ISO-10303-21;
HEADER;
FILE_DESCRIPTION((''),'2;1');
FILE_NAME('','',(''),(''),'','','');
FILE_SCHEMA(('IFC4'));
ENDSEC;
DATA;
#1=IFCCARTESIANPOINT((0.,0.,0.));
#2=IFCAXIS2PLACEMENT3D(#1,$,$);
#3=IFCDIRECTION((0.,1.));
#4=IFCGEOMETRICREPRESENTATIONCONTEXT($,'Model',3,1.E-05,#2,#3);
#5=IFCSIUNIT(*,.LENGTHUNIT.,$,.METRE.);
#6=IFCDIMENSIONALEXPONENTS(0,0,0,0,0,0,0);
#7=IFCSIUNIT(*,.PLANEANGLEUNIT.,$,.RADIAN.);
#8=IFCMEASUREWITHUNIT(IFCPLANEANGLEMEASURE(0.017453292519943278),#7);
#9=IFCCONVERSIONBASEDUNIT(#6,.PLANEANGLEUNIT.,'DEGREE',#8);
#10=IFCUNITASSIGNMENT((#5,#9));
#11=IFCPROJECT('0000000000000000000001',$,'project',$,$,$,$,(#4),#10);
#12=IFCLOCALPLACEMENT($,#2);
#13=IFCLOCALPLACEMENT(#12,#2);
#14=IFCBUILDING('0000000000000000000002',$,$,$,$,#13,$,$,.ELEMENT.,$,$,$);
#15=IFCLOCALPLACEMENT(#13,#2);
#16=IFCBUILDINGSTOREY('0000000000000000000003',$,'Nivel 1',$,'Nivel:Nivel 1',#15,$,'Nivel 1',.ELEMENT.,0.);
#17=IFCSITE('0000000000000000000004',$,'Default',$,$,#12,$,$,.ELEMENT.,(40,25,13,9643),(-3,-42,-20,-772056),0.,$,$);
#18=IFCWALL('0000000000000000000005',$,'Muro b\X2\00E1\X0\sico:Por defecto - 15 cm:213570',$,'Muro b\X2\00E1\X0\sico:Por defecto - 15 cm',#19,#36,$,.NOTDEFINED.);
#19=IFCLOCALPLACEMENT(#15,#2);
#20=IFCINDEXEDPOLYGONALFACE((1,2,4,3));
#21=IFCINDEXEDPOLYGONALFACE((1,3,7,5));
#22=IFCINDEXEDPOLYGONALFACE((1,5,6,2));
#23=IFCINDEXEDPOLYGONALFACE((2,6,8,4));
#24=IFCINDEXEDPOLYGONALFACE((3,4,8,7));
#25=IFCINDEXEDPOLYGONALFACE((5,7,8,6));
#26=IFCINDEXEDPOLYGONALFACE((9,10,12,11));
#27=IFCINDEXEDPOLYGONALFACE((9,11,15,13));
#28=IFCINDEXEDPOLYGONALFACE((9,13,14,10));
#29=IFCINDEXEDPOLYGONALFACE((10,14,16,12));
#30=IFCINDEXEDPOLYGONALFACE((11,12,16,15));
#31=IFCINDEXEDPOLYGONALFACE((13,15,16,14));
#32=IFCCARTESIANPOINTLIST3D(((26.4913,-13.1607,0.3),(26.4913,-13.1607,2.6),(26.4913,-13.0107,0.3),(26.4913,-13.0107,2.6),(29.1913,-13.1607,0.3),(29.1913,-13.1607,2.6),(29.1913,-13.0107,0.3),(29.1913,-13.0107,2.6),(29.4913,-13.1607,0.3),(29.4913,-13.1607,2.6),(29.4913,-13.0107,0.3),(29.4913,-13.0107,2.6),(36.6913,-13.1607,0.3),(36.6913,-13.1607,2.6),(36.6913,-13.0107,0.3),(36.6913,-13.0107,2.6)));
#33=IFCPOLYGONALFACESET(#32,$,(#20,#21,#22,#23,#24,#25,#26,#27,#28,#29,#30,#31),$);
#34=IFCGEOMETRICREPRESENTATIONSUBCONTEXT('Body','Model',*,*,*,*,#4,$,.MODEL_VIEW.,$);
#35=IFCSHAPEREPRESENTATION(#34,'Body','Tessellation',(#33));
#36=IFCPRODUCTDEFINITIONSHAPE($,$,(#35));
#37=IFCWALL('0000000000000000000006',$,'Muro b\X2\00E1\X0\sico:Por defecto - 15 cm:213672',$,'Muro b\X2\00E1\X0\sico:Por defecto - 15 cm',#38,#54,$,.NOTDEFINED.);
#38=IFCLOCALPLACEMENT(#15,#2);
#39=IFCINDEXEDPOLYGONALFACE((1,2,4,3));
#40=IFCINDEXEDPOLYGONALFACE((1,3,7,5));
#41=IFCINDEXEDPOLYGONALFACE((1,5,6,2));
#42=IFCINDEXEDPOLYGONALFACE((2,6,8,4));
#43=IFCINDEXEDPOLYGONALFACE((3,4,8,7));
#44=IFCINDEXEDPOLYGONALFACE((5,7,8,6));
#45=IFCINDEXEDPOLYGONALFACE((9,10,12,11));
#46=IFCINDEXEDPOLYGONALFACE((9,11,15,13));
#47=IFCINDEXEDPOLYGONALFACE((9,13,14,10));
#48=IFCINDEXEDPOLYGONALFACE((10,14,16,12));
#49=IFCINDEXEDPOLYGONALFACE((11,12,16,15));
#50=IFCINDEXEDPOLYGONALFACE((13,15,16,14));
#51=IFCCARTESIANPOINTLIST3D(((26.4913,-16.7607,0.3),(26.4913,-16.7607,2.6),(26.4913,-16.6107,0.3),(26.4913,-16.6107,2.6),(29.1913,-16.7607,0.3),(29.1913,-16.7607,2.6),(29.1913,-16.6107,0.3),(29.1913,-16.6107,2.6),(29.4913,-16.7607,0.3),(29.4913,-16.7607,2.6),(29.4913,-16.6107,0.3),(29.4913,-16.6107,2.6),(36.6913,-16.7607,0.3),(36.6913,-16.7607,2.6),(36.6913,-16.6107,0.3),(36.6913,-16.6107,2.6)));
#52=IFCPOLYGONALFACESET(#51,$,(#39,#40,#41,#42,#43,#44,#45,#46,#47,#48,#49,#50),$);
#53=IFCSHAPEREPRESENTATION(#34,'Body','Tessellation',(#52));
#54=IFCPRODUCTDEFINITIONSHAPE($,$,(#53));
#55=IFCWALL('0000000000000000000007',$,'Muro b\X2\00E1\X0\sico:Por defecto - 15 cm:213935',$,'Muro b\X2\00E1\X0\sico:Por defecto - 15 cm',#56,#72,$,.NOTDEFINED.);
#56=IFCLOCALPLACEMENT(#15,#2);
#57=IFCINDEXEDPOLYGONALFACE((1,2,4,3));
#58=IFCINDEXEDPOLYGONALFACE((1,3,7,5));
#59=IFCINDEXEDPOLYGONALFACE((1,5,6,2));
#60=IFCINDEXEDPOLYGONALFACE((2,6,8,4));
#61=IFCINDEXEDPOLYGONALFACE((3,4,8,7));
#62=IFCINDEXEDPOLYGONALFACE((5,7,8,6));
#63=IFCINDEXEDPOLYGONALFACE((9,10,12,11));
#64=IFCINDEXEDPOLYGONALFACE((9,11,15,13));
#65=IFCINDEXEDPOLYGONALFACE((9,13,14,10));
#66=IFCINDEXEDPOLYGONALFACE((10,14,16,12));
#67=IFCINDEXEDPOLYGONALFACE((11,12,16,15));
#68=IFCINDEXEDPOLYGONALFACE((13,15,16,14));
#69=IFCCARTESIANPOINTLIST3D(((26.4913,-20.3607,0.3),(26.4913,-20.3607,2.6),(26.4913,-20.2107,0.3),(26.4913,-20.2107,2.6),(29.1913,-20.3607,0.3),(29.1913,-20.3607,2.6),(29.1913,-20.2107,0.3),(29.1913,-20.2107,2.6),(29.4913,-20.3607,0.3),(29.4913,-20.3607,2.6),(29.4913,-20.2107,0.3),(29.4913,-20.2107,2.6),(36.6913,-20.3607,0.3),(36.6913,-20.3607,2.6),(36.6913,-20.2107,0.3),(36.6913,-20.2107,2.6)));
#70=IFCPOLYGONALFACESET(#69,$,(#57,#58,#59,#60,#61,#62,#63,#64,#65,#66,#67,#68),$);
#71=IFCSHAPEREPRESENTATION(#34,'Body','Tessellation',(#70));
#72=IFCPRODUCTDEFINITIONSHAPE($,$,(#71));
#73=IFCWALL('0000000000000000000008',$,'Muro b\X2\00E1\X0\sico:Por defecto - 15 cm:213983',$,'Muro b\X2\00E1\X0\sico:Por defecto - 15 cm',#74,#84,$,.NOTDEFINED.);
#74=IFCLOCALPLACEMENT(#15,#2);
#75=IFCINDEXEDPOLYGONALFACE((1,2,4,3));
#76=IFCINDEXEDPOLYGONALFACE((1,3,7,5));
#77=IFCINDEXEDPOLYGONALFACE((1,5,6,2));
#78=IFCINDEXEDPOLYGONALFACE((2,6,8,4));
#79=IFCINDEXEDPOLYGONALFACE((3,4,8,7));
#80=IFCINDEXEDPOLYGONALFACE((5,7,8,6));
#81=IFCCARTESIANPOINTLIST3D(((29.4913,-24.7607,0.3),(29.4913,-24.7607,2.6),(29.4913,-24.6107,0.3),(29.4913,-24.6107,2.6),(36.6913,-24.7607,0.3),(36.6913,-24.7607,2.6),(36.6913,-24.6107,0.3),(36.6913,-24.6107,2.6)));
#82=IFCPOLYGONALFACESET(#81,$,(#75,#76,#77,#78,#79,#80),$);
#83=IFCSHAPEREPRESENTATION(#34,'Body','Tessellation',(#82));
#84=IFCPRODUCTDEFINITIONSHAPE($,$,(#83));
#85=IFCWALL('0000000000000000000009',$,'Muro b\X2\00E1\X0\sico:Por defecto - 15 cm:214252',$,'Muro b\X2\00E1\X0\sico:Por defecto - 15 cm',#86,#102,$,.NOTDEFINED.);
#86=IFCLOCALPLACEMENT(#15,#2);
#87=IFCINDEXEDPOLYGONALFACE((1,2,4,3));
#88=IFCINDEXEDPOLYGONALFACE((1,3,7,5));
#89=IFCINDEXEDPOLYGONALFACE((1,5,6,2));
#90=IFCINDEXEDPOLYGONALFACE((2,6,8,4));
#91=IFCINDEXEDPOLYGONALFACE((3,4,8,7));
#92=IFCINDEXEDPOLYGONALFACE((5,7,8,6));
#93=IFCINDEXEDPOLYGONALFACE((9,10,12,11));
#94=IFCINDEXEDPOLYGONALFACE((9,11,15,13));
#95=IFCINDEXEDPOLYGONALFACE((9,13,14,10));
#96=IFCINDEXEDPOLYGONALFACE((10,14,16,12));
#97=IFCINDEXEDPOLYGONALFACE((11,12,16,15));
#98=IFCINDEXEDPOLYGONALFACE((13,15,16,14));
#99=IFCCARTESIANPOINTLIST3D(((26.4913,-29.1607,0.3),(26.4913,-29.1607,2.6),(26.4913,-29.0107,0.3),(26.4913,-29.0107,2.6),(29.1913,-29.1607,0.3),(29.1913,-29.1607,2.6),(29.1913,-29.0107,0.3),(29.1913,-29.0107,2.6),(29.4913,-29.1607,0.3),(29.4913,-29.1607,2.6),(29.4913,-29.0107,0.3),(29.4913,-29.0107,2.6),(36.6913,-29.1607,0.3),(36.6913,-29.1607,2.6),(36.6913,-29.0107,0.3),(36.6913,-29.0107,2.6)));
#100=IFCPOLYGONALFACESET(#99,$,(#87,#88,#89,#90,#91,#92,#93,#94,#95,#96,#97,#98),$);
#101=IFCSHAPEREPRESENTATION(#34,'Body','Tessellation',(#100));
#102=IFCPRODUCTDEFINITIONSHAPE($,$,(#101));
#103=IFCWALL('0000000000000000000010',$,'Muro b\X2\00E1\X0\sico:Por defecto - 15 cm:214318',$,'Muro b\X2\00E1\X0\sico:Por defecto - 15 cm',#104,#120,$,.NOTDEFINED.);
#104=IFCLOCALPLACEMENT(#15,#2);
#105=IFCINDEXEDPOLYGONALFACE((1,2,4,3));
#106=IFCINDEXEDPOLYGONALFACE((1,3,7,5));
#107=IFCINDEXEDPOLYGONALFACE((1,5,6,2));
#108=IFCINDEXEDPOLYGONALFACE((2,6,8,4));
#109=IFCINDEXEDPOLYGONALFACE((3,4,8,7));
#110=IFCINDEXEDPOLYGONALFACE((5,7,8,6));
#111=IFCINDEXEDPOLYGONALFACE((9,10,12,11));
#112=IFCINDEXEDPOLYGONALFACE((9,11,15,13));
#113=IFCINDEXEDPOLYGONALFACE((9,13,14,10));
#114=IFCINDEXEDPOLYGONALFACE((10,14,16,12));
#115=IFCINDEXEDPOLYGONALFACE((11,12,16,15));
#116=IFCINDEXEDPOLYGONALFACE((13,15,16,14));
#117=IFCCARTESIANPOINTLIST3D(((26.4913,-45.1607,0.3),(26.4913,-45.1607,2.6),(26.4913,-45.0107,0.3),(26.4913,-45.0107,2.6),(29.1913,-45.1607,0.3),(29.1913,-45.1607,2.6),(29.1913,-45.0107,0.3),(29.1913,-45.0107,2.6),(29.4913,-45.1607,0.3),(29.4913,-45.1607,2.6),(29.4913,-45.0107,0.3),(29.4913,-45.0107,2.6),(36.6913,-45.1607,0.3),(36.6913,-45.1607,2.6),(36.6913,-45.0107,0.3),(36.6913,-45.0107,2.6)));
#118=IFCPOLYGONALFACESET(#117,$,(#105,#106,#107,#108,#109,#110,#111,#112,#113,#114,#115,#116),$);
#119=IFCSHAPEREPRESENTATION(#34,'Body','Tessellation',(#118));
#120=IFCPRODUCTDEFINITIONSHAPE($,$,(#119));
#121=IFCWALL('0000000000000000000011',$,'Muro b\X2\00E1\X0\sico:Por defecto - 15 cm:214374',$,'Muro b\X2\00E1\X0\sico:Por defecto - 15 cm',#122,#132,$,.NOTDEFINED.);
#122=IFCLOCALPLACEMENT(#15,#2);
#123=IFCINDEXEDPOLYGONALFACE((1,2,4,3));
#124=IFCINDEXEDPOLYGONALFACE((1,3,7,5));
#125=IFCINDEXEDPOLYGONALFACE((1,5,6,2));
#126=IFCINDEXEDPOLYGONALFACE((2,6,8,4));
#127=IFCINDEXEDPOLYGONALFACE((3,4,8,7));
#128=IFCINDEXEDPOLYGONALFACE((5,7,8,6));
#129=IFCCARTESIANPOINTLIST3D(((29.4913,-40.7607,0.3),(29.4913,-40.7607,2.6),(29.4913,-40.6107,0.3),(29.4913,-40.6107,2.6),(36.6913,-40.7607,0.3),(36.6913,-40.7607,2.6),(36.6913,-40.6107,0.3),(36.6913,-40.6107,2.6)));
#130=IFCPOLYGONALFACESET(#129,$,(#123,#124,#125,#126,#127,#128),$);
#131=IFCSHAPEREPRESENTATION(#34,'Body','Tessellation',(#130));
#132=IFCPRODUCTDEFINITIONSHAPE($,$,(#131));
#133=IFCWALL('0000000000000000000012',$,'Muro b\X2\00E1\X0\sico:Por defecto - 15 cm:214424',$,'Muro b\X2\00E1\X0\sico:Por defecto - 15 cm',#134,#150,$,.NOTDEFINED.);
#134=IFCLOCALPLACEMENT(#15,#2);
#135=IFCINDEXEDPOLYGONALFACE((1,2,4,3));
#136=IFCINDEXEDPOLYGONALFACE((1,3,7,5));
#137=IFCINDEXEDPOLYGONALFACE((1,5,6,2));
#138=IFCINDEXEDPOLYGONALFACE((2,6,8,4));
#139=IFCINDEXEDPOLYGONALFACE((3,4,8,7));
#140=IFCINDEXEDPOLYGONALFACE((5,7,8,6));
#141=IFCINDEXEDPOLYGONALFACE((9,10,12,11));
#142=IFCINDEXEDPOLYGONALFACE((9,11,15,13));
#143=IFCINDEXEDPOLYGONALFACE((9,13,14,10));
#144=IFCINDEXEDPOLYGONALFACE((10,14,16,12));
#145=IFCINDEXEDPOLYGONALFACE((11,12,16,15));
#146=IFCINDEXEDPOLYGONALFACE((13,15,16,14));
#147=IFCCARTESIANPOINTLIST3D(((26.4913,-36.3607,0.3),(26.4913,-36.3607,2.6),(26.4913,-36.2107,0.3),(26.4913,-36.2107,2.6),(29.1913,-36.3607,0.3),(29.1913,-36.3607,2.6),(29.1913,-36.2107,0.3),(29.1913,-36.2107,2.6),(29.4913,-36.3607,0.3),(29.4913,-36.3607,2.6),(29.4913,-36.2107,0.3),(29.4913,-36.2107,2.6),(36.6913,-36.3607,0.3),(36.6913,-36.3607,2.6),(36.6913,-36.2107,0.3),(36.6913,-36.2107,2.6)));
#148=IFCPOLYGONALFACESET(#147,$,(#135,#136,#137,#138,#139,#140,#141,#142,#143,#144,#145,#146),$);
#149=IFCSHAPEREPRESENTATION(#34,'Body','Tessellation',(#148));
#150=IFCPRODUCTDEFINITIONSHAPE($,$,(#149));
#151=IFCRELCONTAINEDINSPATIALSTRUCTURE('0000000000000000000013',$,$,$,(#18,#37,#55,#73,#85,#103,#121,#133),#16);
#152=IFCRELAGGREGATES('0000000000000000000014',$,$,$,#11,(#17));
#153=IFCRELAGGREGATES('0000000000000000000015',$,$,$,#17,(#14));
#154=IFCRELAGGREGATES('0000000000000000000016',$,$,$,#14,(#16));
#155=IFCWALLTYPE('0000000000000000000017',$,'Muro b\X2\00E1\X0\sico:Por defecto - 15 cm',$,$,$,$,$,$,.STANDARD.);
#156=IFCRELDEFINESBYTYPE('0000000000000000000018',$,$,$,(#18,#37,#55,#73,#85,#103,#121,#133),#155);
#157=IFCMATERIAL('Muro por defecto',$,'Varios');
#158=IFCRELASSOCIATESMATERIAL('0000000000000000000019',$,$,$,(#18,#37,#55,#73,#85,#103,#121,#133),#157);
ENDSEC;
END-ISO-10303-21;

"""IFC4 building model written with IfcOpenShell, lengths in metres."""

from ifc_helpers import new_model, entity, si_unit, converted_unit, direction, frame, origin, place, context, subcontext, project, spatial, indexed_curve, outline, extrude, material, type_object, element, save


model = new_model("IFC4")

# Units and contexts
model_context = context("Model", 3, precision=1e-05, world=origin(), true_north=direction((0.0, 1.0)))
body_context = subcontext(model_context, "Body", "Model", "MODEL_VIEW")
ifc_project = project(units=[si_unit("LENGTHUNIT", "METRE"), converted_unit("PLANEANGLEUNIT", "DEGREE", entity("IfcPlaneAngleMeasure", 0.017453292519943278), si_unit("PLANEANGLEUNIT", "RADIAN"), dimensions=[0, 0, 0, 0, 0, 0, 0])], contexts=[model_context])

# Site, building, storey
site_placement = place(None, origin())
site = spatial("IfcSite", under=ifc_project, at=site_placement, Name="Default", CompositionType="ELEMENT", RefLatitude=(40, 25, 13, 9643), RefLongitude=(-3, -42, -20, -772056), RefElevation=0.0)
building_placement = place(site_placement, origin())
building = spatial("IfcBuilding", under=site, at=building_placement, CompositionType="ELEMENT")
storey_placement = place(building_placement, origin())
storey = spatial("IfcBuildingStorey", under=building, at=storey_placement, Name="Nivel 1", ObjectType="Nivel:Nivel 1", LongName="Nivel 1", CompositionType="ELEMENT", Elevation=0.0)

# Walls, openings
ifc_material = material(Name="Muro por defecto", Category="Varios")
wall_type_1 = type_object("IfcWallType", Name="Muro básico:Por defecto - 15 cm", PredefinedType="STANDARD")
wall_1_placement = place(storey_placement, frame((26.4913, -13.0857, 0.3)))
wall_1 = element("IfcWall", 1, at=wall_1_placement, inside=storey, type_object=wall_type_1, material=ifc_material, Name="Muro básico:Por defecto - 15 cm:213570", ObjectType="Muro básico:Por defecto - 15 cm", PredefinedType="NOTDEFINED", context=body_context, shape_type="SweptSolid", body=[
    extrude(outline(indexed_curve([(10.2, 0.075), (0.0, 0.075), (0.0, -0.075), (10.2, -0.075), (10.2, 0.075)], self_intersect=False)), origin(), (0.0, 0.0, 1.0), 2.3),
])
opening_1_placement = place(storey_placement, frame((26.4913, -13.0857, 0.3)))
element("IfcOpeningElement", 2, at=opening_1_placement, cuts=wall_1, PredefinedType="OPENING", context=body_context, shape_type="SweptSolid", body=[
    extrude(outline(indexed_curve([(-1.15, -0.075), (1.15, -0.075), (1.15, 0.075), (-1.15, 0.075), (-1.15, -0.075)], self_intersect=False)), frame((2.7, 0.0, 1.15), z_axis=(1.0, 0.0, 0.0), x_axis=(0.0, 0.0, -1.0)), (0.0, 0.0, 1.0), 0.3),
])
wall_2_placement = place(storey_placement, frame((26.4913, -16.6857, 0.3)))
wall_2 = element("IfcWall", 3, at=wall_2_placement, inside=storey, type_object=wall_type_1, material=ifc_material, Name="Muro básico:Por defecto - 15 cm:213672", ObjectType="Muro básico:Por defecto - 15 cm", PredefinedType="NOTDEFINED", context=body_context, shape_type="SweptSolid", body=[
    extrude(outline(indexed_curve([(10.2, 0.075), (0.0, 0.075), (0.0, -0.075), (10.2, -0.075), (10.2, 0.075)], self_intersect=False)), origin(), (0.0, 0.0, 1.0), 2.3),
])
opening_2_placement = place(storey_placement, frame((26.4913, -16.6857, 0.3)))
element("IfcOpeningElement", 4, at=opening_2_placement, cuts=wall_2, PredefinedType="OPENING", context=body_context, shape_type="SweptSolid", body=[
    extrude(outline(indexed_curve([(-1.15, -0.075), (1.15, -0.075), (1.15, 0.075), (-1.15, 0.075), (-1.15, -0.075)], self_intersect=False)), frame((2.7, 0.0, 1.15), z_axis=(1.0, 0.0, 0.0), x_axis=(0.0, 0.0, -1.0)), (0.0, 0.0, 1.0), 0.3),
])
wall_3_placement = place(storey_placement, frame((36.6913, -20.2857, 0.3), z_axis=(0.0, 0.0, 1.0), x_axis=(-1.0, 0.0, 0.0)))
wall_3 = element("IfcWall", 5, at=wall_3_placement, inside=storey, type_object=wall_type_1, material=ifc_material, Name="Muro básico:Por defecto - 15 cm:213935", ObjectType="Muro básico:Por defecto - 15 cm", PredefinedType="NOTDEFINED", context=body_context, shape_type="SweptSolid", body=[
    extrude(outline(indexed_curve([(10.2, 0.075), (0.0, 0.075), (0.0, -0.075), (10.2, -0.075), (10.2, 0.075)], self_intersect=False)), origin(), (0.0, 0.0, 1.0), 2.3),
])
opening_3_placement = place(storey_placement, frame((36.6913, -20.2857, 0.3), z_axis=(0.0, 0.0, 1.0), x_axis=(-1.0, 0.0, 0.0)))
element("IfcOpeningElement", 6, at=opening_3_placement, cuts=wall_3, PredefinedType="OPENING", context=body_context, shape_type="SweptSolid", body=[
    extrude(outline(indexed_curve([(-1.15, -0.075), (1.15, -0.075), (1.15, 0.075), (-1.15, 0.075), (-1.15, -0.075)], self_intersect=False)), frame((7.5, 0.0, 1.15), z_axis=(-1.0, 0.0, 0.0), x_axis=(0.0, 0.0, 1.0)), (0.0, 0.0, 1.0), 0.3),
])

# Wall
wall_4_placement = place(storey_placement, frame((36.6913, -24.6857, 0.3), z_axis=(0.0, 0.0, 1.0), x_axis=(-1.0, 0.0, 0.0)))
element("IfcWall", 7, at=wall_4_placement, inside=storey, type_object=wall_type_1, material=ifc_material, Name="Muro básico:Por defecto - 15 cm:213983", ObjectType="Muro básico:Por defecto - 15 cm", PredefinedType="NOTDEFINED", context=body_context, shape_type="SweptSolid", body=[
    extrude(outline(indexed_curve([(7.2, 0.075), (0.0, 0.075), (0.0, -0.075), (7.2, -0.075), (7.2, 0.075)], self_intersect=False)), origin(), (0.0, 0.0, 1.0), 2.3),
])

# Walls, openings
wall_5_placement = place(storey_placement, frame((36.6913, -29.0857, 0.3), z_axis=(0.0, 0.0, 1.0), x_axis=(-1.0, 0.0, 0.0)))
wall_5 = element("IfcWall", 8, at=wall_5_placement, inside=storey, type_object=wall_type_1, material=ifc_material, Name="Muro básico:Por defecto - 15 cm:214252", ObjectType="Muro básico:Por defecto - 15 cm", PredefinedType="NOTDEFINED", context=body_context, shape_type="SweptSolid", body=[
    extrude(outline(indexed_curve([(10.2, 0.075), (0.0, 0.075), (0.0, -0.075), (10.2, -0.075), (10.2, 0.075)], self_intersect=False)), origin(), (0.0, 0.0, 1.0), 2.3),
])
opening_4_placement = place(storey_placement, frame((36.6913, -29.0857, 0.3), z_axis=(0.0, 0.0, 1.0), x_axis=(-1.0, 0.0, 0.0)))
element("IfcOpeningElement", 9, at=opening_4_placement, cuts=wall_5, PredefinedType="OPENING", context=body_context, shape_type="SweptSolid", body=[
    extrude(outline(indexed_curve([(-1.15, -0.075), (1.15, -0.075), (1.15, 0.075), (-1.15, 0.075), (-1.15, -0.075)], self_intersect=False)), frame((7.5, 0.0, 1.15), z_axis=(-1.0, 0.0, 0.0), x_axis=(0.0, 0.0, 1.0)), (0.0, 0.0, 1.0), 0.3),
])
wall_6_placement = place(storey_placement, frame((36.6913, -45.0857, 0.3), z_axis=(0.0, 0.0, 1.0), x_axis=(-1.0, 0.0, 0.0)))
wall_6 = element("IfcWall", 10, at=wall_6_placement, inside=storey, type_object=wall_type_1, material=ifc_material, Name="Muro básico:Por defecto - 15 cm:214318", ObjectType="Muro básico:Por defecto - 15 cm", PredefinedType="NOTDEFINED", context=body_context, shape_type="SweptSolid", body=[
    extrude(outline(indexed_curve([(10.2, 0.075), (0.0, 0.075), (0.0, -0.075), (10.2, -0.075), (10.2, 0.075)], self_intersect=False)), origin(), (0.0, 0.0, 1.0), 2.3),
])
opening_5_placement = place(storey_placement, frame((36.6913, -45.0857, 0.3), z_axis=(0.0, 0.0, 1.0), x_axis=(-1.0, 0.0, 0.0)))
element("IfcOpeningElement", 11, at=opening_5_placement, cuts=wall_6, PredefinedType="OPENING", context=body_context, shape_type="SweptSolid", body=[
    extrude(outline(indexed_curve([(-1.15, -0.075), (1.15, -0.075), (1.15, 0.075), (-1.15, 0.075), (-1.15, -0.075)], self_intersect=False)), frame((7.5, 0.0, 1.15), z_axis=(-1.0, 0.0, 0.0), x_axis=(0.0, 0.0, 1.0)), (0.0, 0.0, 1.0), 0.3),
])

# Wall
wall_7_placement = place(storey_placement, frame((36.6913, -40.6857, 0.3), z_axis=(0.0, 0.0, 1.0), x_axis=(-1.0, 0.0, 0.0)))
element("IfcWall", 12, at=wall_7_placement, inside=storey, type_object=wall_type_1, material=ifc_material, Name="Muro básico:Por defecto - 15 cm:214374", ObjectType="Muro básico:Por defecto - 15 cm", PredefinedType="NOTDEFINED", context=body_context, shape_type="SweptSolid", body=[
    extrude(outline(indexed_curve([(7.2, 0.075), (0.0, 0.075), (0.0, -0.075), (7.2, -0.075), (7.2, 0.075)], self_intersect=False)), origin(), (0.0, 0.0, 1.0), 2.3),
])

# Wall, opening
wall_8_placement = place(storey_placement, frame((36.6913, -36.2857, 0.3), z_axis=(0.0, 0.0, 1.0), x_axis=(-1.0, 0.0, 0.0)))
wall_8 = element("IfcWall", 13, at=wall_8_placement, inside=storey, type_object=wall_type_1, material=ifc_material, Name="Muro básico:Por defecto - 15 cm:214424", ObjectType="Muro básico:Por defecto - 15 cm", PredefinedType="NOTDEFINED", context=body_context, shape_type="SweptSolid", body=[
    extrude(outline(indexed_curve([(10.2, 0.075), (0.0, 0.075), (0.0, -0.075), (10.2, -0.075), (10.2, 0.075)], self_intersect=False)), origin(), (0.0, 0.0, 1.0), 2.3),
])
opening_6_placement = place(storey_placement, frame((36.6913, -36.2857, 0.3), z_axis=(0.0, 0.0, 1.0), x_axis=(-1.0, 0.0, 0.0)))
element("IfcOpeningElement", 14, at=opening_6_placement, cuts=wall_8, PredefinedType="OPENING", context=body_context, shape_type="SweptSolid", body=[
    extrude(outline(indexed_curve([(-1.15, -0.075), (1.15, -0.075), (1.15, 0.075), (-1.15, 0.075), (-1.15, -0.075)], self_intersect=False)), frame((7.5, 0.0, 1.15), z_axis=(-1.0, 0.0, 0.0), x_axis=(0.0, 0.0, 1.0)), (0.0, 0.0, 1.0), 0.3),
])

save(model, "model.ifc")
